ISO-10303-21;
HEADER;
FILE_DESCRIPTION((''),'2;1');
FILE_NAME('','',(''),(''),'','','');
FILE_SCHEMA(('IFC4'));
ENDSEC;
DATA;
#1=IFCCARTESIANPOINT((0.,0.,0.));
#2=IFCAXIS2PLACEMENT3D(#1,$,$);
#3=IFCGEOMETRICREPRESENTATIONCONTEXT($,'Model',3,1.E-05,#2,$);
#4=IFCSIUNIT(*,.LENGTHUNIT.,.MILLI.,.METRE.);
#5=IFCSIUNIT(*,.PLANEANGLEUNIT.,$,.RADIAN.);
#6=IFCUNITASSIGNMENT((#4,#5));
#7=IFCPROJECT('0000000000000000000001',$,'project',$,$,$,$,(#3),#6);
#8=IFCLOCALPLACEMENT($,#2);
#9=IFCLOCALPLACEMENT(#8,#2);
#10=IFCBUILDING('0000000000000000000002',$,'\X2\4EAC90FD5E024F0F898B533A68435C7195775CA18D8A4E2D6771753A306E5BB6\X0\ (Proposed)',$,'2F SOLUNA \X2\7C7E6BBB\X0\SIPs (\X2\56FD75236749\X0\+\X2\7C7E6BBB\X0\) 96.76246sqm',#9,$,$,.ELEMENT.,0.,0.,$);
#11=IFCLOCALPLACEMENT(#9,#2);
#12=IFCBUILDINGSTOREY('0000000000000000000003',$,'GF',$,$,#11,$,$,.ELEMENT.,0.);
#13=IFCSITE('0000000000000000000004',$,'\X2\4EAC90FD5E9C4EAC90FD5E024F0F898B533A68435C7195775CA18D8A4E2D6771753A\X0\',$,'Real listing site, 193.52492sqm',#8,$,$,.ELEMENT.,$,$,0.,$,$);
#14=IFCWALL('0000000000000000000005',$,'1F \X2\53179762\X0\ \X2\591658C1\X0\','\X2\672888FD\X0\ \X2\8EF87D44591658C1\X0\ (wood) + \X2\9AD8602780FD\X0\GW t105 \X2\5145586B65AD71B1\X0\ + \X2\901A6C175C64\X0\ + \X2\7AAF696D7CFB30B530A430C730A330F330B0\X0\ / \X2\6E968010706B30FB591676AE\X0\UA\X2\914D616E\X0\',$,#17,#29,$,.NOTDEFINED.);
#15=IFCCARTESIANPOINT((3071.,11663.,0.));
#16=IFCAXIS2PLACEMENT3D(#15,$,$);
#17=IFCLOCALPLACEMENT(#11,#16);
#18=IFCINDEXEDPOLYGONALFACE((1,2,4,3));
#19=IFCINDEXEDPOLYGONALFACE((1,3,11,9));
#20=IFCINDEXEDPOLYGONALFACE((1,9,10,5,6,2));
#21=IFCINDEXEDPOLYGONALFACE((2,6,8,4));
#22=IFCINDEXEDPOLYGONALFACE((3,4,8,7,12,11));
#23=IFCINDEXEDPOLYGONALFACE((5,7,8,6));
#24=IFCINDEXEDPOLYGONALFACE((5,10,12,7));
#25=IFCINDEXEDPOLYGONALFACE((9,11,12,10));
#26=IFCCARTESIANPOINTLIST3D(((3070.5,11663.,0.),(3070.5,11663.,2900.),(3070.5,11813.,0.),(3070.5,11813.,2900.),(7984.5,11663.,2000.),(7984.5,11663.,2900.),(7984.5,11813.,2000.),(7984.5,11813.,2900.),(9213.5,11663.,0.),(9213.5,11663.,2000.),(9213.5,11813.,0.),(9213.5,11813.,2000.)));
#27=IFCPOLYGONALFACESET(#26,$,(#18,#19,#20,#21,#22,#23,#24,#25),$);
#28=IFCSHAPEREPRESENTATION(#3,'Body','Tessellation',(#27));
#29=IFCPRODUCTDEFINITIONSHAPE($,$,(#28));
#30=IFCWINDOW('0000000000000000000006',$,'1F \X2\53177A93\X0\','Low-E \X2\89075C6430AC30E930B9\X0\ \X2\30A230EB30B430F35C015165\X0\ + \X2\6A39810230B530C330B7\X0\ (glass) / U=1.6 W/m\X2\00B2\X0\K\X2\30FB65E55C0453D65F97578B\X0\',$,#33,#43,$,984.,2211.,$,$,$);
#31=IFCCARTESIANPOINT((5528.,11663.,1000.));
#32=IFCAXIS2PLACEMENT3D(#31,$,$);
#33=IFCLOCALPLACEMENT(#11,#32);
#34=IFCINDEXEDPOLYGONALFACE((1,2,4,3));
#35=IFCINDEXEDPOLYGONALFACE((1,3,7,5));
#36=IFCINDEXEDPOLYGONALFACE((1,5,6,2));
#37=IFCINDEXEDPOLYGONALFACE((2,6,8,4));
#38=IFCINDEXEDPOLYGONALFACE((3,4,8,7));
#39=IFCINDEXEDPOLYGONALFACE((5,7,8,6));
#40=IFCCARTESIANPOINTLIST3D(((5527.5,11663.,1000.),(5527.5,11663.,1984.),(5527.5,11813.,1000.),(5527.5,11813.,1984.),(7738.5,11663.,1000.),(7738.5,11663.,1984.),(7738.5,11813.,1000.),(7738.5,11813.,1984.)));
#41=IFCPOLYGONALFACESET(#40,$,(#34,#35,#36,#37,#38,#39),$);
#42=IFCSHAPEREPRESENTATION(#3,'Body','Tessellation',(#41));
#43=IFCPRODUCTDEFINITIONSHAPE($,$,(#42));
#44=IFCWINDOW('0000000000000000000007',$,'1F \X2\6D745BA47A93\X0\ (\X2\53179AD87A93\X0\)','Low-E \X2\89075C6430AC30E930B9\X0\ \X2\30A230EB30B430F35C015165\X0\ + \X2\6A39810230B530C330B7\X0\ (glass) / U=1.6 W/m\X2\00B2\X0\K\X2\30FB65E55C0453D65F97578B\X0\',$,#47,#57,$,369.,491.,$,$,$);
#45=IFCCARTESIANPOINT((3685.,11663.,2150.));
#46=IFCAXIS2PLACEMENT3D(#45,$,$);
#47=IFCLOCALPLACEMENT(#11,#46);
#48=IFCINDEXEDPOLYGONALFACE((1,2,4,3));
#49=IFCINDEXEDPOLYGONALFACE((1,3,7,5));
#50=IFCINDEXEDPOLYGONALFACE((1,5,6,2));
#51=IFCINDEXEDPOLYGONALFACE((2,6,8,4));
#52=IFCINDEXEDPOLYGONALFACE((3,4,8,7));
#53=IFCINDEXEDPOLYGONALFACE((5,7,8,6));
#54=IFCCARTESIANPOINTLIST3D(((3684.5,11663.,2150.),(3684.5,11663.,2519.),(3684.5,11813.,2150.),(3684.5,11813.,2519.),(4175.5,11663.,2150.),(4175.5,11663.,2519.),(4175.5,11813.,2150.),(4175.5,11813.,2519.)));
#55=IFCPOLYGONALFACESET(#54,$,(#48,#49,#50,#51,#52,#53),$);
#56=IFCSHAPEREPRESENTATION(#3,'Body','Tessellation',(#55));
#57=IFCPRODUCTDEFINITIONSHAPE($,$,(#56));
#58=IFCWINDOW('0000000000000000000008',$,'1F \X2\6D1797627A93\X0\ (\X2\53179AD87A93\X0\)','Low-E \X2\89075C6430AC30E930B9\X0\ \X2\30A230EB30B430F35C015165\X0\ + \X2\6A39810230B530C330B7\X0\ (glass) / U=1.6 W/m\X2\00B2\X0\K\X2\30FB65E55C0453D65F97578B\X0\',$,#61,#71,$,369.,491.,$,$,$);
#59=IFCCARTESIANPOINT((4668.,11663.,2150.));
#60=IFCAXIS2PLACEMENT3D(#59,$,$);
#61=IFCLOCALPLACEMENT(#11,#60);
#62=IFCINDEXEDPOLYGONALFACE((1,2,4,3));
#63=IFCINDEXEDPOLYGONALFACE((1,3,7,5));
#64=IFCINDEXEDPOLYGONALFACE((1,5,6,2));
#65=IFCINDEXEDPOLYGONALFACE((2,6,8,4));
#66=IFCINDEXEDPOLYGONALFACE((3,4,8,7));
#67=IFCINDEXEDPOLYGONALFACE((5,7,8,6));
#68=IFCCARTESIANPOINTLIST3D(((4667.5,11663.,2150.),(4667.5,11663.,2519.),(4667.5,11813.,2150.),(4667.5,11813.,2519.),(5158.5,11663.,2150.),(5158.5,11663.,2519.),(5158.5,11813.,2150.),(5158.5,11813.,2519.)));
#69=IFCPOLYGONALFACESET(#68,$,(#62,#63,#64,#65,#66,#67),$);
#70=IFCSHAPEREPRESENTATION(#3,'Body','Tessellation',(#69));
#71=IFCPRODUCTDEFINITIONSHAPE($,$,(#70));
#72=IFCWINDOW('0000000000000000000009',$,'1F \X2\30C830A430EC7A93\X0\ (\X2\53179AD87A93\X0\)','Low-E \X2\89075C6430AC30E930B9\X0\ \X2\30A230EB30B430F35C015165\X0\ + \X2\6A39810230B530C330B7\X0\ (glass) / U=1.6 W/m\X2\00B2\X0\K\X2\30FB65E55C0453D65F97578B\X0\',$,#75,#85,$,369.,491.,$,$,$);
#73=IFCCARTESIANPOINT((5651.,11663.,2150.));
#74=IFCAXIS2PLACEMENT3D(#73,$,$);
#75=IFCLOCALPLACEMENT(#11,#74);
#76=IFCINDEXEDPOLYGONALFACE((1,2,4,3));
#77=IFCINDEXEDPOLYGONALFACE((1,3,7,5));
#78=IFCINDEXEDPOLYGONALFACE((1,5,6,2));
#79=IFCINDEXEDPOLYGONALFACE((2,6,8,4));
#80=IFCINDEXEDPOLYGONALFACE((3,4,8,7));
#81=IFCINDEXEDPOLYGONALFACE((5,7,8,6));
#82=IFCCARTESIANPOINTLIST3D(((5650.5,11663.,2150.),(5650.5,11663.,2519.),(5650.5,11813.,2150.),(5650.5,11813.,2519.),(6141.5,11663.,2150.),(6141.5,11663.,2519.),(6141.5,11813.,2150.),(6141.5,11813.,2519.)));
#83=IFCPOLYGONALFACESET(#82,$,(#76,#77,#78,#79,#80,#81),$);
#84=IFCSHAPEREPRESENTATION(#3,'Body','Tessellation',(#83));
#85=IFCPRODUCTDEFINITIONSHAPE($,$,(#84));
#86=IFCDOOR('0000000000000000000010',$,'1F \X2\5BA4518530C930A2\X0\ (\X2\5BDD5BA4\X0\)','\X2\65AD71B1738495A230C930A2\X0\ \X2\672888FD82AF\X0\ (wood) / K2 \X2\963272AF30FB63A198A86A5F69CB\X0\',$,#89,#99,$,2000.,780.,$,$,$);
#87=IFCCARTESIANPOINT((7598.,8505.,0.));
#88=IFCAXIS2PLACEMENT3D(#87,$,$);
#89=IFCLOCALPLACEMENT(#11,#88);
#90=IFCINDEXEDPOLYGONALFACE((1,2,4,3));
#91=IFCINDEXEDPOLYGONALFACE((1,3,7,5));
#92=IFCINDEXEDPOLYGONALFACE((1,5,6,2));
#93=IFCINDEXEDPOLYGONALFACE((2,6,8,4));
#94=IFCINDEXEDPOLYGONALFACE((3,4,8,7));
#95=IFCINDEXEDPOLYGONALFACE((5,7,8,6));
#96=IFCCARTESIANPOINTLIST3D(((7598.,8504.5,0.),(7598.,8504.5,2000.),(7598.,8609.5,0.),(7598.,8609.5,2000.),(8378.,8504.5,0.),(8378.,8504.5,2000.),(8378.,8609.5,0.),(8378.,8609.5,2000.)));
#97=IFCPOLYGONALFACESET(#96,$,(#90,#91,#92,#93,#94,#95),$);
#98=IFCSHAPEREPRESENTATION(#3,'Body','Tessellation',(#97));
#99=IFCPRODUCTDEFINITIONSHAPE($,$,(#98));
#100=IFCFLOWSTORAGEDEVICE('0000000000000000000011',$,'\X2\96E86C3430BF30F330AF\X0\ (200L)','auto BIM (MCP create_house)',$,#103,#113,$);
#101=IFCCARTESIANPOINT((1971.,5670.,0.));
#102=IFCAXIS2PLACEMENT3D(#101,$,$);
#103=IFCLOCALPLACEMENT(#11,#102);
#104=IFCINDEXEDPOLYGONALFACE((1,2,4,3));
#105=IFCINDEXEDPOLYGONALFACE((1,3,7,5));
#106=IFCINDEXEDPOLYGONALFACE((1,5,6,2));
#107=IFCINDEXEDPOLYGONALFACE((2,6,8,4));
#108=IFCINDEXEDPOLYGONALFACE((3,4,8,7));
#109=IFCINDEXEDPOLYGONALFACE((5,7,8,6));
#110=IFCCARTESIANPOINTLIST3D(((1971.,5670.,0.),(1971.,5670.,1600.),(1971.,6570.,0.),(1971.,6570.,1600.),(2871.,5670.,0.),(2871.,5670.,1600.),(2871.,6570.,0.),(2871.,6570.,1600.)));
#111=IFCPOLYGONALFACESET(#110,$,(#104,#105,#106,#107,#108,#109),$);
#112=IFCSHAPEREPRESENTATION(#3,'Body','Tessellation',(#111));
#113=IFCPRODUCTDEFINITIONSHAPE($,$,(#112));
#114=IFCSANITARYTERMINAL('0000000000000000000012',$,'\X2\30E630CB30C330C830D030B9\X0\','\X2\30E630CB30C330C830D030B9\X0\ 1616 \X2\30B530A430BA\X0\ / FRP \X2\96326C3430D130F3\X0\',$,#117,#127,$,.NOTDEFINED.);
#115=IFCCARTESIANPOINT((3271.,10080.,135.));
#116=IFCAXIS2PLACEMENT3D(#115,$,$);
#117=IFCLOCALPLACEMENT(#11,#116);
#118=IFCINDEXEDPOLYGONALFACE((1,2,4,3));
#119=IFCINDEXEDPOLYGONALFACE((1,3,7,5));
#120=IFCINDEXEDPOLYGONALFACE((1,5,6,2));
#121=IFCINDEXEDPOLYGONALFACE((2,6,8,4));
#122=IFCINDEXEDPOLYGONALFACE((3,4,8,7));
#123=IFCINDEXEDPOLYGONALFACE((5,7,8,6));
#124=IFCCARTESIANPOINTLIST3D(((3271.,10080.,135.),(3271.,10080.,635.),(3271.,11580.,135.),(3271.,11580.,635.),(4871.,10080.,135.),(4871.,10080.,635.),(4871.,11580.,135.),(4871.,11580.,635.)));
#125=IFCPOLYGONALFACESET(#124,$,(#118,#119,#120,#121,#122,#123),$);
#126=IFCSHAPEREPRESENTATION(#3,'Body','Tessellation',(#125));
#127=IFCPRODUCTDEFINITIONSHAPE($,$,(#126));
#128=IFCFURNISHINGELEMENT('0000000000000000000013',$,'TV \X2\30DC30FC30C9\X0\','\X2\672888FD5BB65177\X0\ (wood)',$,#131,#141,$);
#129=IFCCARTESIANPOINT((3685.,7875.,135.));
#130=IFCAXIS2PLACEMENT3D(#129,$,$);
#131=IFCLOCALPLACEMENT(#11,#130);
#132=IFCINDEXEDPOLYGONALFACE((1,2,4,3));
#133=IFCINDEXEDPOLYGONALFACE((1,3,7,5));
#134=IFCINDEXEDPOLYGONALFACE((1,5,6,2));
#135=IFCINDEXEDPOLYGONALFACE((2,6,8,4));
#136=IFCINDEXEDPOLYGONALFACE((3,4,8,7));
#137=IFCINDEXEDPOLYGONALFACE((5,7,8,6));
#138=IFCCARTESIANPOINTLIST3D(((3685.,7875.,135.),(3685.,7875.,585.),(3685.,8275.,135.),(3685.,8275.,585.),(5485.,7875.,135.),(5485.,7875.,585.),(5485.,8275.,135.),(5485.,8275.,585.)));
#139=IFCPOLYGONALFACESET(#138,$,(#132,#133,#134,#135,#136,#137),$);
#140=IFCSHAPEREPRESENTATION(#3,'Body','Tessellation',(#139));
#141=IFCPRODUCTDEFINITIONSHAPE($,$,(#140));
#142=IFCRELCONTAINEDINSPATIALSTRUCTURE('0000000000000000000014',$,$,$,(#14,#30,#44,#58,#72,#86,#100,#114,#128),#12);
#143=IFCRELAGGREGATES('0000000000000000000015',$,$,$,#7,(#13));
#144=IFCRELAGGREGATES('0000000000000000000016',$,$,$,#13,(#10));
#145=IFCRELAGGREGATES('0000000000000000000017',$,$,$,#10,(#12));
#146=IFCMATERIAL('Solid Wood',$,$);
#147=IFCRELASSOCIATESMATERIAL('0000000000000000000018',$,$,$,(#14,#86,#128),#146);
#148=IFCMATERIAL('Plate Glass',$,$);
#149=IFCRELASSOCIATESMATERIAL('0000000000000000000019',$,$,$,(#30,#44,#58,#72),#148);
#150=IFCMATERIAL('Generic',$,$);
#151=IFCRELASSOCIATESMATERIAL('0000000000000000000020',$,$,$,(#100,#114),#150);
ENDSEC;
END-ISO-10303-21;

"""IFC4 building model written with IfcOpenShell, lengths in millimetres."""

from ifc_helpers import new_model, si_unit, frame, frame_2d, origin, place, context, project, spatial, rectangle, extrude, material, element, fill, save


model = new_model("IFC4")

# Units and contexts
model_context = context("Model", 3, precision=1e-05, world=origin())
ifc_project = project(units=[si_unit("LENGTHUNIT", "METRE", prefix="MILLI"), si_unit("PLANEANGLEUNIT", "RADIAN")], contexts=[model_context])

# Site, building, storey
site_placement = place(None, origin())
site = spatial("IfcSite", under=ifc_project, at=site_placement, Name="京都府京都市伏見区桃山長岡越中東町", ObjectType="Real listing site, 193.52492sqm", CompositionType="ELEMENT", RefElevation=0.0)
building_placement = place(site_placement, origin())
building = spatial("IfcBuilding", under=site, at=building_placement, Name="京都市伏見区桃山長岡越中東町の家 (Proposed)", ObjectType="2F SOLUNA 籾殻SIPs (国産杉+籾殻) 96.76246sqm", CompositionType="ELEMENT", ElevationOfRefHeight=0.0, ElevationOfTerrain=0.0)
storey_placement = place(building_placement, origin())
storey = spatial("IfcBuildingStorey", under=building, at=storey_placement, Name="GF", CompositionType="ELEMENT", Elevation=0.0)

# Wall, openings, windows
ifc_material_1 = material(Name="Solid Wood")
wall_1_placement = place(storey_placement, frame((3071.0, 11663.0, 0.0)))
wall_1 = element("IfcWall", 1, at=wall_1_placement, inside=storey, material=ifc_material_1, Name="1F 北面 外壁", Description="木製 軸組外壁 (wood) + 高性能GW t105 充填断熱 + 通気層 + 窯業系サイディング / 準耐火・外皮UA配慮", PredefinedType="NOTDEFINED", context=model_context, shape_type="SweptSolid", body=[
    extrude(rectangle(XDim=6143.0, YDim=150.0, at=frame_2d((3071.0, 75.0))), frame((3071.0, 11663.0, 0.0)), (0.0, 0.0, 1.0), 2900.0),
])
opening_1_placement = place(storey_placement, frame((5528.0, 11663.0, 1000.0)))
opening_1 = element("IfcOpeningElement", 2, at=opening_1_placement, cuts=wall_1, PredefinedType="NOTDEFINED", context=model_context, shape_type="SweptSolid", body=[
    extrude(rectangle(XDim=2211.0, YDim=150.0, at=frame_2d((1105.0, 75.0))), frame((5528.0, 11663.0, 1000.0)), (0.0, 0.0, 1.0), 984.0),
])
opening_2_placement = place(storey_placement, frame((3685.0, 11663.0, 2150.0)))
opening_2 = element("IfcOpeningElement", 3, at=opening_2_placement, cuts=wall_1, PredefinedType="NOTDEFINED", context=model_context, shape_type="SweptSolid", body=[
    extrude(rectangle(XDim=491.0, YDim=150.0, at=frame_2d((245.0, 75.0))), frame((3685.0, 11663.0, 2150.0)), (0.0, 0.0, 1.0), 369.0),
])
opening_3_placement = place(storey_placement, frame((4668.0, 11663.0, 2150.0)))
opening_3 = element("IfcOpeningElement", 4, at=opening_3_placement, cuts=wall_1, PredefinedType="NOTDEFINED", context=model_context, shape_type="SweptSolid", body=[
    extrude(rectangle(XDim=491.0, YDim=150.0, at=frame_2d((245.0, 75.0))), frame((4668.0, 11663.0, 2150.0)), (0.0, 0.0, 1.0), 369.0),
])
opening_4_placement = place(storey_placement, frame((5651.0, 11663.0, 2150.0)))
opening_4 = element("IfcOpeningElement", 5, at=opening_4_placement, cuts=wall_1, PredefinedType="NOTDEFINED", context=model_context, shape_type="SweptSolid", body=[
    extrude(rectangle(XDim=491.0, YDim=150.0, at=frame_2d((245.0, 75.0))), frame((5651.0, 11663.0, 2150.0)), (0.0, 0.0, 1.0), 369.0),
])
ifc_material_2 = material(Name="Plate Glass")
window_1_placement = place(storey_placement, frame((5528.0, 11663.0, 1000.0)))
window_1 = element("IfcWindow", 6, at=window_1_placement, inside=storey, material=ifc_material_2, Name="1F 北窓", Description="Low-E 複層ガラス アルゴン封入 + 樹脂サッシ (glass) / U=1.6 W/m²K・日射取得型", OverallHeight=984.0, OverallWidth=2211.0, context=model_context, shape_type="SweptSolid", body=[
    extrude(rectangle(XDim=2211.0, YDim=150.0, at=frame_2d((1105.0, 75.0))), frame((5528.0, 11663.0, 1000.0)), (0.0, 0.0, 1.0), 984.0),
])
fill(opening_1, window_1)
window_2_placement = place(storey_placement, frame((3685.0, 11663.0, 2150.0)))
window_2 = element("IfcWindow", 7, at=window_2_placement, inside=storey, material=ifc_material_2, Name="1F 浴室窓 (北高窓)", Description="Low-E 複層ガラス アルゴン封入 + 樹脂サッシ (glass) / U=1.6 W/m²K・日射取得型", OverallHeight=369.0, OverallWidth=491.0, context=model_context, shape_type="SweptSolid", body=[
    extrude(rectangle(XDim=491.0, YDim=150.0, at=frame_2d((245.0, 75.0))), frame((3685.0, 11663.0, 2150.0)), (0.0, 0.0, 1.0), 369.0),
])
fill(opening_2, window_2)
window_3_placement = place(storey_placement, frame((4668.0, 11663.0, 2150.0)))
window_3 = element("IfcWindow", 8, at=window_3_placement, inside=storey, material=ifc_material_2, Name="1F 洗面窓 (北高窓)", Description="Low-E 複層ガラス アルゴン封入 + 樹脂サッシ (glass) / U=1.6 W/m²K・日射取得型", OverallHeight=369.0, OverallWidth=491.0, context=model_context, shape_type="SweptSolid", body=[
    extrude(rectangle(XDim=491.0, YDim=150.0, at=frame_2d((245.0, 75.0))), frame((4668.0, 11663.0, 2150.0)), (0.0, 0.0, 1.0), 369.0),
])
fill(opening_3, window_3)
window_4_placement = place(storey_placement, frame((5651.0, 11663.0, 2150.0)))
window_4 = element("IfcWindow", 9, at=window_4_placement, inside=storey, material=ifc_material_2, Name="1F トイレ窓 (北高窓)", Description="Low-E 複層ガラス アルゴン封入 + 樹脂サッシ (glass) / U=1.6 W/m²K・日射取得型", OverallHeight=369.0, OverallWidth=491.0, context=model_context, shape_type="SweptSolid", body=[
    extrude(rectangle(XDim=491.0, YDim=150.0, at=frame_2d((245.0, 75.0))), frame((5651.0, 11663.0, 2150.0)), (0.0, 0.0, 1.0), 369.0),
])
fill(opening_4, window_4)

# Door
door_1_placement = place(storey_placement, frame((7598.0, 8505.0, 0.0)))
element("IfcDoor", 10, at=door_1_placement, inside=storey, material=ifc_material_1, Name="1F 室内ドア (寝室)", Description="断熱玄関ドア 木製芯 (wood) / K2 防犯・採風機構", OverallHeight=2000.0, OverallWidth=780.0, context=model_context, shape_type="SweptSolid", body=[
    extrude(rectangle(XDim=780.0, YDim=105.0, at=frame_2d((390.0, 52.0))), frame((7598.0, 8505.0, 0.0)), (0.0, 0.0, 1.0), 2000.0),
])

# Flow storage device
ifc_material_3 = material(Name="Generic")
flow_storage_device_placement = place(storey_placement, frame((1971.0, 5670.0, 0.0)))
element("IfcFlowStorageDevice", 11, at=flow_storage_device_placement, inside=storey, material=ifc_material_3, Name="雨水タンク (200L)", Description="auto BIM (MCP create_house)", context=model_context, shape_type="SweptSolid", body=[
    extrude(rectangle(XDim=900.0, YDim=900.0, at=frame_2d((450.0, 450.0))), frame((1971.0, 5670.0, 0.0)), (0.0, 0.0, 1.0), 1600.0),
])

# Sanitary terminal
sanitary_terminal_placement = place(storey_placement, frame((3271.0, 10080.0, 135.0)))
element("IfcSanitaryTerminal", 12, at=sanitary_terminal_placement, inside=storey, material=ifc_material_3, Name="ユニットバス", Description="ユニットバス 1616 サイズ / FRP 防水パン", PredefinedType="NOTDEFINED", context=model_context, shape_type="SweptSolid", body=[
    extrude(rectangle(XDim=1600.0, YDim=1500.0, at=frame_2d((800.0, 750.0))), frame((3271.0, 10080.0, 135.0)), (0.0, 0.0, 1.0), 500.0),
])

# Furnishing element
furnishing_placement = place(storey_placement, frame((3685.0, 7875.0, 135.0)))
element("IfcFurnishingElement", 13, at=furnishing_placement, inside=storey, material=ifc_material_1, Name="TV ボード", Description="木製家具 (wood)", context=model_context, shape_type="SweptSolid", body=[
    extrude(rectangle(XDim=1800.0, YDim=400.0, at=frame_2d((900.0, 200.0))), frame((3685.0, 7875.0, 135.0)), (0.0, 0.0, 1.0), 450.0),
])

save(model, "model.ifc")
